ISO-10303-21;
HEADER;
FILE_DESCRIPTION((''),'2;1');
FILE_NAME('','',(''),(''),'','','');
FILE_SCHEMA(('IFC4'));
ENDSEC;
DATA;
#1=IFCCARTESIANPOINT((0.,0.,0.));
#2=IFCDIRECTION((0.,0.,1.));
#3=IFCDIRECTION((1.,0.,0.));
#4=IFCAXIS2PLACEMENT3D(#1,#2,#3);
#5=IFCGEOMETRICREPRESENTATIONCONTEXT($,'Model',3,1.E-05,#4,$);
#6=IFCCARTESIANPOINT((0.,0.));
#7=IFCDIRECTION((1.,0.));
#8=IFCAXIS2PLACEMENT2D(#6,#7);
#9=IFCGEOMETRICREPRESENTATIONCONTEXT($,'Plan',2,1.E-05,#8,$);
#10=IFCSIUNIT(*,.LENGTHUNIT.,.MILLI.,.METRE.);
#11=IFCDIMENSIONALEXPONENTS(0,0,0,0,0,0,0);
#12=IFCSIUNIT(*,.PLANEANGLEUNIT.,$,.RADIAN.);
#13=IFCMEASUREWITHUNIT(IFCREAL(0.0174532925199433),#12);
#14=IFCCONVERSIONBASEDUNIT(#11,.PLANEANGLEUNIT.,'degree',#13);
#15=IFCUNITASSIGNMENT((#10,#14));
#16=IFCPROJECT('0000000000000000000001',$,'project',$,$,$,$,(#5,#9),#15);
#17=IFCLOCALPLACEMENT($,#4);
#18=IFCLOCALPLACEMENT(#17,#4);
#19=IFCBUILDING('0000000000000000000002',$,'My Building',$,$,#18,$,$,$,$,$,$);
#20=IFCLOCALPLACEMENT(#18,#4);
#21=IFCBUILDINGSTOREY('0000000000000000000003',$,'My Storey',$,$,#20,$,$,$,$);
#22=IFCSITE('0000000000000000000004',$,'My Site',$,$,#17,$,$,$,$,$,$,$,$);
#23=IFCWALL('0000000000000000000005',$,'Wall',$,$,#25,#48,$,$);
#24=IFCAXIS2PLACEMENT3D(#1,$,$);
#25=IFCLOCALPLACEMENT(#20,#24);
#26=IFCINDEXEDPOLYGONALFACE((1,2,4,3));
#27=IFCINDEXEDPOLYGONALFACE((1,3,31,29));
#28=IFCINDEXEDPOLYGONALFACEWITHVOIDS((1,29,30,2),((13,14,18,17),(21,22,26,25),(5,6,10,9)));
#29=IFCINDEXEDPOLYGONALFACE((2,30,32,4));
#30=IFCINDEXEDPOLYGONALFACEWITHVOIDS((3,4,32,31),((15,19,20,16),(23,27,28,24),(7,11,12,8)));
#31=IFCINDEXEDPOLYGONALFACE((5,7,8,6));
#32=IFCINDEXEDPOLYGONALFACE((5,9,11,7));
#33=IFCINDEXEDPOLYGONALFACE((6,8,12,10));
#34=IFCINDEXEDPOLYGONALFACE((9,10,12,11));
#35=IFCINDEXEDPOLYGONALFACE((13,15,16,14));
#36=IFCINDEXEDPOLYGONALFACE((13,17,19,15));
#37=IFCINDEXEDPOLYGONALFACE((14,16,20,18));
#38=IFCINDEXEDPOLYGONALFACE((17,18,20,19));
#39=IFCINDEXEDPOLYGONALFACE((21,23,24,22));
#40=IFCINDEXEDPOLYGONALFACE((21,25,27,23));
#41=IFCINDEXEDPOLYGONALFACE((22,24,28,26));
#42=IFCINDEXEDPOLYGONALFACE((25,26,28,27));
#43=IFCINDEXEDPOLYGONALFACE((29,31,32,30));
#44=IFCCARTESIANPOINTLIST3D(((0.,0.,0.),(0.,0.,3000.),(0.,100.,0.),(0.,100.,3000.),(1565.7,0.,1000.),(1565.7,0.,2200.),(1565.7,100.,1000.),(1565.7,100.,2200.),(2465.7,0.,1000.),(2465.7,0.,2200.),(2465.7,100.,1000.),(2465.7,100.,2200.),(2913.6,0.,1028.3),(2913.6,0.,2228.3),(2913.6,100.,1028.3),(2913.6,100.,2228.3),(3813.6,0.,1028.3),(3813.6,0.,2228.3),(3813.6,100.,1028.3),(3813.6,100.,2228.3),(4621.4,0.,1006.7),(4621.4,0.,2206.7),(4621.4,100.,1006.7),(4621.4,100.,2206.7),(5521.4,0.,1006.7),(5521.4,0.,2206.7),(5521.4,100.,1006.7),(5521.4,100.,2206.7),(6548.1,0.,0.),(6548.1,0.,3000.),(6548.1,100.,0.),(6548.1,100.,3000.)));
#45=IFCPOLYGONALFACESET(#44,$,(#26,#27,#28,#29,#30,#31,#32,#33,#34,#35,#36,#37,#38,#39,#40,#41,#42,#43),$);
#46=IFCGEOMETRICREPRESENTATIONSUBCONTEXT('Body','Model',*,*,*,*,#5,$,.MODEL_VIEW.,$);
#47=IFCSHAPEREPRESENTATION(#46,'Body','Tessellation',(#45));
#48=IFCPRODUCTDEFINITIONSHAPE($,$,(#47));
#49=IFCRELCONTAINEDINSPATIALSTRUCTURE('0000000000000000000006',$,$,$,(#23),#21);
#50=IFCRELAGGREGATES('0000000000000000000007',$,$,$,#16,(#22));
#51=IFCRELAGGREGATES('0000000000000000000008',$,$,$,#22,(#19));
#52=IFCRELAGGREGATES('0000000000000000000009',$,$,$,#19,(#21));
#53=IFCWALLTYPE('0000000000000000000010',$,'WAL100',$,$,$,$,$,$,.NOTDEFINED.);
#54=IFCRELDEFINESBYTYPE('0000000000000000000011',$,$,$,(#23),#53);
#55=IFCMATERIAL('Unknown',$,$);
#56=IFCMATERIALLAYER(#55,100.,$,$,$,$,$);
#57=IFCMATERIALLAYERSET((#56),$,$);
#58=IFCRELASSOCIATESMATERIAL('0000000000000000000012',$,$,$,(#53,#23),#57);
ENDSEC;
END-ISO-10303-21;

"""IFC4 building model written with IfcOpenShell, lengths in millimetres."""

from ifc_helpers import new_model, entity, si_unit, converted_unit, frame, origin_with_axes, origin_2d_with_axis, place, context, subcontext, project, spatial, line, indexed_curve, outline, extrude, source, transform, mapped, material, layer, layer_set, layer_usage, type_object, element, save


model = new_model("IFC4")

# Units and contexts
model_context = context("Model", 3, precision=1e-05, world=origin_with_axes())
plan_context = context("Plan", 2, precision=1e-05, world=origin_2d_with_axis())
body_context = subcontext(model_context, "Body", "Model", "MODEL_VIEW")
ifc_project = project(units=[si_unit("LENGTHUNIT", "METRE", prefix="MILLI"), converted_unit("PLANEANGLEUNIT", "degree", entity("IfcReal", 0.0174532925199433), si_unit("PLANEANGLEUNIT", "RADIAN"), dimensions=[0, 0, 0, 0, 0, 0, 0])], contexts=[model_context, plan_context])

# Site, building, storey
site_placement = place(None, origin_with_axes())
site = spatial("IfcSite", under=ifc_project, at=site_placement, Name="My Site")
building_placement = place(site_placement, origin_with_axes())
building = spatial("IfcBuilding", under=site, at=building_placement, Name="My Building")
storey_placement = place(building_placement, origin_with_axes())
storey = spatial("IfcBuildingStorey", under=building, at=storey_placement, Name="My Storey")

# Wall, openings
ifc_material = material(Name="Unknown")
ifc_layer = layer(ifc_material, 100.0)
ifc_layer_set = layer_set([ifc_layer])
ifc_layer_usage = layer_usage(ifc_layer_set, "AXIS2", "POSITIVE", 0.0)
wall_type = type_object("IfcWallType", Name="WAL100", PredefinedType="NOTDEFINED", material=ifc_layer_set)
wall_placement = place(storey_placement, origin_with_axes())
wall = element("IfcWall", 1, at=wall_placement, inside=storey, type_object=wall_type, material=ifc_layer_usage, Name="Wall", context=body_context, shape_type="SweptSolid", body=[
    extrude(outline(indexed_curve([(0.0, 0.0), (0.0, 100.0), (6548.1, 100.0), (6548.1, 0.0), (0.0, 0.0)], self_intersect=False)), origin_with_axes(), (0.0, 0.0, 1.0), 3000.0),
])
shared_shape_1 = source(origin_with_axes(), body_context, "Body", "SweptSolid", [
    extrude(outline(indexed_curve([(0.0, 0.0), (900.0, 0.0), (900.0, 1200.0), (0.0, 1200.0)], segments=[line(1, 2, 3, 4, 1)])), frame((0.0, -600.0, 0.0), z_axis=(0.0, -1.0, 0.0), x_axis=(1.0, 0.0, 0.0)), (0.0, 0.0, -1.0), 1200.0),
])
opening_1_placement = place(wall_placement, frame((1565.7, 0.0, 1000.0), z_axis=(0.0, 0.0, 1.0), x_axis=(1.0, 0.0, 0.0)))
element("IfcOpeningElement", 2, at=opening_1_placement, cuts=wall, PredefinedType="OPENING", context=body_context, shape_type="MappedRepresentation", body=[
    mapped(shared_shape_1, transform((0.0, 0.0, 0.0), x_axis=(1.0, 0.0, 0.0), y_axis=(0.0, 1.0, 0.0), z_axis=(0.0, 0.0, 1.0), scale=1.0)),
])
shared_shape_2 = source(origin_with_axes(), body_context, "Body", "SweptSolid", [
    extrude(outline(indexed_curve([(0.0, 0.0), (900.0, 0.0), (900.0, 1200.0), (0.0, 1200.0)], segments=[line(1, 2, 3, 4, 1)])), frame((0.0, -600.0, 0.0), z_axis=(0.0, -1.0, 0.0), x_axis=(1.0, 0.0, 0.0)), (0.0, 0.0, -1.0), 1200.0),
])
opening_2_placement = place(wall_placement, frame((2913.6, 0.0, 1028.3), z_axis=(0.0, 0.0, 1.0), x_axis=(1.0, 0.0, 0.0)))
element("IfcOpeningElement", 3, at=opening_2_placement, cuts=wall, PredefinedType="OPENING", context=body_context, shape_type="MappedRepresentation", body=[
    mapped(shared_shape_2, transform((0.0, 0.0, 0.0), x_axis=(1.0, 0.0, 0.0), y_axis=(0.0, 1.0, 0.0), z_axis=(0.0, 0.0, 1.0), scale=1.0)),
])
opening_3_placement = place(wall_placement, frame((5521.4, 0.0, 2206.7), z_axis=(0.0, 0.0, -1.0), x_axis=(-1.0, 0.0, 0.0)))
element("IfcOpeningElement", 4, at=opening_3_placement, cuts=wall, PredefinedType="OPENING", context=body_context, shape_type="MappedRepresentation", body=[
    mapped(shared_shape_2, transform((0.0, 0.0, 0.0), x_axis=(1.0, 0.0, 0.0), y_axis=(0.0, 1.0, 0.0), z_axis=(0.0, 0.0, 1.0), scale=1.0)),
])

save(model, "model.ifc")
